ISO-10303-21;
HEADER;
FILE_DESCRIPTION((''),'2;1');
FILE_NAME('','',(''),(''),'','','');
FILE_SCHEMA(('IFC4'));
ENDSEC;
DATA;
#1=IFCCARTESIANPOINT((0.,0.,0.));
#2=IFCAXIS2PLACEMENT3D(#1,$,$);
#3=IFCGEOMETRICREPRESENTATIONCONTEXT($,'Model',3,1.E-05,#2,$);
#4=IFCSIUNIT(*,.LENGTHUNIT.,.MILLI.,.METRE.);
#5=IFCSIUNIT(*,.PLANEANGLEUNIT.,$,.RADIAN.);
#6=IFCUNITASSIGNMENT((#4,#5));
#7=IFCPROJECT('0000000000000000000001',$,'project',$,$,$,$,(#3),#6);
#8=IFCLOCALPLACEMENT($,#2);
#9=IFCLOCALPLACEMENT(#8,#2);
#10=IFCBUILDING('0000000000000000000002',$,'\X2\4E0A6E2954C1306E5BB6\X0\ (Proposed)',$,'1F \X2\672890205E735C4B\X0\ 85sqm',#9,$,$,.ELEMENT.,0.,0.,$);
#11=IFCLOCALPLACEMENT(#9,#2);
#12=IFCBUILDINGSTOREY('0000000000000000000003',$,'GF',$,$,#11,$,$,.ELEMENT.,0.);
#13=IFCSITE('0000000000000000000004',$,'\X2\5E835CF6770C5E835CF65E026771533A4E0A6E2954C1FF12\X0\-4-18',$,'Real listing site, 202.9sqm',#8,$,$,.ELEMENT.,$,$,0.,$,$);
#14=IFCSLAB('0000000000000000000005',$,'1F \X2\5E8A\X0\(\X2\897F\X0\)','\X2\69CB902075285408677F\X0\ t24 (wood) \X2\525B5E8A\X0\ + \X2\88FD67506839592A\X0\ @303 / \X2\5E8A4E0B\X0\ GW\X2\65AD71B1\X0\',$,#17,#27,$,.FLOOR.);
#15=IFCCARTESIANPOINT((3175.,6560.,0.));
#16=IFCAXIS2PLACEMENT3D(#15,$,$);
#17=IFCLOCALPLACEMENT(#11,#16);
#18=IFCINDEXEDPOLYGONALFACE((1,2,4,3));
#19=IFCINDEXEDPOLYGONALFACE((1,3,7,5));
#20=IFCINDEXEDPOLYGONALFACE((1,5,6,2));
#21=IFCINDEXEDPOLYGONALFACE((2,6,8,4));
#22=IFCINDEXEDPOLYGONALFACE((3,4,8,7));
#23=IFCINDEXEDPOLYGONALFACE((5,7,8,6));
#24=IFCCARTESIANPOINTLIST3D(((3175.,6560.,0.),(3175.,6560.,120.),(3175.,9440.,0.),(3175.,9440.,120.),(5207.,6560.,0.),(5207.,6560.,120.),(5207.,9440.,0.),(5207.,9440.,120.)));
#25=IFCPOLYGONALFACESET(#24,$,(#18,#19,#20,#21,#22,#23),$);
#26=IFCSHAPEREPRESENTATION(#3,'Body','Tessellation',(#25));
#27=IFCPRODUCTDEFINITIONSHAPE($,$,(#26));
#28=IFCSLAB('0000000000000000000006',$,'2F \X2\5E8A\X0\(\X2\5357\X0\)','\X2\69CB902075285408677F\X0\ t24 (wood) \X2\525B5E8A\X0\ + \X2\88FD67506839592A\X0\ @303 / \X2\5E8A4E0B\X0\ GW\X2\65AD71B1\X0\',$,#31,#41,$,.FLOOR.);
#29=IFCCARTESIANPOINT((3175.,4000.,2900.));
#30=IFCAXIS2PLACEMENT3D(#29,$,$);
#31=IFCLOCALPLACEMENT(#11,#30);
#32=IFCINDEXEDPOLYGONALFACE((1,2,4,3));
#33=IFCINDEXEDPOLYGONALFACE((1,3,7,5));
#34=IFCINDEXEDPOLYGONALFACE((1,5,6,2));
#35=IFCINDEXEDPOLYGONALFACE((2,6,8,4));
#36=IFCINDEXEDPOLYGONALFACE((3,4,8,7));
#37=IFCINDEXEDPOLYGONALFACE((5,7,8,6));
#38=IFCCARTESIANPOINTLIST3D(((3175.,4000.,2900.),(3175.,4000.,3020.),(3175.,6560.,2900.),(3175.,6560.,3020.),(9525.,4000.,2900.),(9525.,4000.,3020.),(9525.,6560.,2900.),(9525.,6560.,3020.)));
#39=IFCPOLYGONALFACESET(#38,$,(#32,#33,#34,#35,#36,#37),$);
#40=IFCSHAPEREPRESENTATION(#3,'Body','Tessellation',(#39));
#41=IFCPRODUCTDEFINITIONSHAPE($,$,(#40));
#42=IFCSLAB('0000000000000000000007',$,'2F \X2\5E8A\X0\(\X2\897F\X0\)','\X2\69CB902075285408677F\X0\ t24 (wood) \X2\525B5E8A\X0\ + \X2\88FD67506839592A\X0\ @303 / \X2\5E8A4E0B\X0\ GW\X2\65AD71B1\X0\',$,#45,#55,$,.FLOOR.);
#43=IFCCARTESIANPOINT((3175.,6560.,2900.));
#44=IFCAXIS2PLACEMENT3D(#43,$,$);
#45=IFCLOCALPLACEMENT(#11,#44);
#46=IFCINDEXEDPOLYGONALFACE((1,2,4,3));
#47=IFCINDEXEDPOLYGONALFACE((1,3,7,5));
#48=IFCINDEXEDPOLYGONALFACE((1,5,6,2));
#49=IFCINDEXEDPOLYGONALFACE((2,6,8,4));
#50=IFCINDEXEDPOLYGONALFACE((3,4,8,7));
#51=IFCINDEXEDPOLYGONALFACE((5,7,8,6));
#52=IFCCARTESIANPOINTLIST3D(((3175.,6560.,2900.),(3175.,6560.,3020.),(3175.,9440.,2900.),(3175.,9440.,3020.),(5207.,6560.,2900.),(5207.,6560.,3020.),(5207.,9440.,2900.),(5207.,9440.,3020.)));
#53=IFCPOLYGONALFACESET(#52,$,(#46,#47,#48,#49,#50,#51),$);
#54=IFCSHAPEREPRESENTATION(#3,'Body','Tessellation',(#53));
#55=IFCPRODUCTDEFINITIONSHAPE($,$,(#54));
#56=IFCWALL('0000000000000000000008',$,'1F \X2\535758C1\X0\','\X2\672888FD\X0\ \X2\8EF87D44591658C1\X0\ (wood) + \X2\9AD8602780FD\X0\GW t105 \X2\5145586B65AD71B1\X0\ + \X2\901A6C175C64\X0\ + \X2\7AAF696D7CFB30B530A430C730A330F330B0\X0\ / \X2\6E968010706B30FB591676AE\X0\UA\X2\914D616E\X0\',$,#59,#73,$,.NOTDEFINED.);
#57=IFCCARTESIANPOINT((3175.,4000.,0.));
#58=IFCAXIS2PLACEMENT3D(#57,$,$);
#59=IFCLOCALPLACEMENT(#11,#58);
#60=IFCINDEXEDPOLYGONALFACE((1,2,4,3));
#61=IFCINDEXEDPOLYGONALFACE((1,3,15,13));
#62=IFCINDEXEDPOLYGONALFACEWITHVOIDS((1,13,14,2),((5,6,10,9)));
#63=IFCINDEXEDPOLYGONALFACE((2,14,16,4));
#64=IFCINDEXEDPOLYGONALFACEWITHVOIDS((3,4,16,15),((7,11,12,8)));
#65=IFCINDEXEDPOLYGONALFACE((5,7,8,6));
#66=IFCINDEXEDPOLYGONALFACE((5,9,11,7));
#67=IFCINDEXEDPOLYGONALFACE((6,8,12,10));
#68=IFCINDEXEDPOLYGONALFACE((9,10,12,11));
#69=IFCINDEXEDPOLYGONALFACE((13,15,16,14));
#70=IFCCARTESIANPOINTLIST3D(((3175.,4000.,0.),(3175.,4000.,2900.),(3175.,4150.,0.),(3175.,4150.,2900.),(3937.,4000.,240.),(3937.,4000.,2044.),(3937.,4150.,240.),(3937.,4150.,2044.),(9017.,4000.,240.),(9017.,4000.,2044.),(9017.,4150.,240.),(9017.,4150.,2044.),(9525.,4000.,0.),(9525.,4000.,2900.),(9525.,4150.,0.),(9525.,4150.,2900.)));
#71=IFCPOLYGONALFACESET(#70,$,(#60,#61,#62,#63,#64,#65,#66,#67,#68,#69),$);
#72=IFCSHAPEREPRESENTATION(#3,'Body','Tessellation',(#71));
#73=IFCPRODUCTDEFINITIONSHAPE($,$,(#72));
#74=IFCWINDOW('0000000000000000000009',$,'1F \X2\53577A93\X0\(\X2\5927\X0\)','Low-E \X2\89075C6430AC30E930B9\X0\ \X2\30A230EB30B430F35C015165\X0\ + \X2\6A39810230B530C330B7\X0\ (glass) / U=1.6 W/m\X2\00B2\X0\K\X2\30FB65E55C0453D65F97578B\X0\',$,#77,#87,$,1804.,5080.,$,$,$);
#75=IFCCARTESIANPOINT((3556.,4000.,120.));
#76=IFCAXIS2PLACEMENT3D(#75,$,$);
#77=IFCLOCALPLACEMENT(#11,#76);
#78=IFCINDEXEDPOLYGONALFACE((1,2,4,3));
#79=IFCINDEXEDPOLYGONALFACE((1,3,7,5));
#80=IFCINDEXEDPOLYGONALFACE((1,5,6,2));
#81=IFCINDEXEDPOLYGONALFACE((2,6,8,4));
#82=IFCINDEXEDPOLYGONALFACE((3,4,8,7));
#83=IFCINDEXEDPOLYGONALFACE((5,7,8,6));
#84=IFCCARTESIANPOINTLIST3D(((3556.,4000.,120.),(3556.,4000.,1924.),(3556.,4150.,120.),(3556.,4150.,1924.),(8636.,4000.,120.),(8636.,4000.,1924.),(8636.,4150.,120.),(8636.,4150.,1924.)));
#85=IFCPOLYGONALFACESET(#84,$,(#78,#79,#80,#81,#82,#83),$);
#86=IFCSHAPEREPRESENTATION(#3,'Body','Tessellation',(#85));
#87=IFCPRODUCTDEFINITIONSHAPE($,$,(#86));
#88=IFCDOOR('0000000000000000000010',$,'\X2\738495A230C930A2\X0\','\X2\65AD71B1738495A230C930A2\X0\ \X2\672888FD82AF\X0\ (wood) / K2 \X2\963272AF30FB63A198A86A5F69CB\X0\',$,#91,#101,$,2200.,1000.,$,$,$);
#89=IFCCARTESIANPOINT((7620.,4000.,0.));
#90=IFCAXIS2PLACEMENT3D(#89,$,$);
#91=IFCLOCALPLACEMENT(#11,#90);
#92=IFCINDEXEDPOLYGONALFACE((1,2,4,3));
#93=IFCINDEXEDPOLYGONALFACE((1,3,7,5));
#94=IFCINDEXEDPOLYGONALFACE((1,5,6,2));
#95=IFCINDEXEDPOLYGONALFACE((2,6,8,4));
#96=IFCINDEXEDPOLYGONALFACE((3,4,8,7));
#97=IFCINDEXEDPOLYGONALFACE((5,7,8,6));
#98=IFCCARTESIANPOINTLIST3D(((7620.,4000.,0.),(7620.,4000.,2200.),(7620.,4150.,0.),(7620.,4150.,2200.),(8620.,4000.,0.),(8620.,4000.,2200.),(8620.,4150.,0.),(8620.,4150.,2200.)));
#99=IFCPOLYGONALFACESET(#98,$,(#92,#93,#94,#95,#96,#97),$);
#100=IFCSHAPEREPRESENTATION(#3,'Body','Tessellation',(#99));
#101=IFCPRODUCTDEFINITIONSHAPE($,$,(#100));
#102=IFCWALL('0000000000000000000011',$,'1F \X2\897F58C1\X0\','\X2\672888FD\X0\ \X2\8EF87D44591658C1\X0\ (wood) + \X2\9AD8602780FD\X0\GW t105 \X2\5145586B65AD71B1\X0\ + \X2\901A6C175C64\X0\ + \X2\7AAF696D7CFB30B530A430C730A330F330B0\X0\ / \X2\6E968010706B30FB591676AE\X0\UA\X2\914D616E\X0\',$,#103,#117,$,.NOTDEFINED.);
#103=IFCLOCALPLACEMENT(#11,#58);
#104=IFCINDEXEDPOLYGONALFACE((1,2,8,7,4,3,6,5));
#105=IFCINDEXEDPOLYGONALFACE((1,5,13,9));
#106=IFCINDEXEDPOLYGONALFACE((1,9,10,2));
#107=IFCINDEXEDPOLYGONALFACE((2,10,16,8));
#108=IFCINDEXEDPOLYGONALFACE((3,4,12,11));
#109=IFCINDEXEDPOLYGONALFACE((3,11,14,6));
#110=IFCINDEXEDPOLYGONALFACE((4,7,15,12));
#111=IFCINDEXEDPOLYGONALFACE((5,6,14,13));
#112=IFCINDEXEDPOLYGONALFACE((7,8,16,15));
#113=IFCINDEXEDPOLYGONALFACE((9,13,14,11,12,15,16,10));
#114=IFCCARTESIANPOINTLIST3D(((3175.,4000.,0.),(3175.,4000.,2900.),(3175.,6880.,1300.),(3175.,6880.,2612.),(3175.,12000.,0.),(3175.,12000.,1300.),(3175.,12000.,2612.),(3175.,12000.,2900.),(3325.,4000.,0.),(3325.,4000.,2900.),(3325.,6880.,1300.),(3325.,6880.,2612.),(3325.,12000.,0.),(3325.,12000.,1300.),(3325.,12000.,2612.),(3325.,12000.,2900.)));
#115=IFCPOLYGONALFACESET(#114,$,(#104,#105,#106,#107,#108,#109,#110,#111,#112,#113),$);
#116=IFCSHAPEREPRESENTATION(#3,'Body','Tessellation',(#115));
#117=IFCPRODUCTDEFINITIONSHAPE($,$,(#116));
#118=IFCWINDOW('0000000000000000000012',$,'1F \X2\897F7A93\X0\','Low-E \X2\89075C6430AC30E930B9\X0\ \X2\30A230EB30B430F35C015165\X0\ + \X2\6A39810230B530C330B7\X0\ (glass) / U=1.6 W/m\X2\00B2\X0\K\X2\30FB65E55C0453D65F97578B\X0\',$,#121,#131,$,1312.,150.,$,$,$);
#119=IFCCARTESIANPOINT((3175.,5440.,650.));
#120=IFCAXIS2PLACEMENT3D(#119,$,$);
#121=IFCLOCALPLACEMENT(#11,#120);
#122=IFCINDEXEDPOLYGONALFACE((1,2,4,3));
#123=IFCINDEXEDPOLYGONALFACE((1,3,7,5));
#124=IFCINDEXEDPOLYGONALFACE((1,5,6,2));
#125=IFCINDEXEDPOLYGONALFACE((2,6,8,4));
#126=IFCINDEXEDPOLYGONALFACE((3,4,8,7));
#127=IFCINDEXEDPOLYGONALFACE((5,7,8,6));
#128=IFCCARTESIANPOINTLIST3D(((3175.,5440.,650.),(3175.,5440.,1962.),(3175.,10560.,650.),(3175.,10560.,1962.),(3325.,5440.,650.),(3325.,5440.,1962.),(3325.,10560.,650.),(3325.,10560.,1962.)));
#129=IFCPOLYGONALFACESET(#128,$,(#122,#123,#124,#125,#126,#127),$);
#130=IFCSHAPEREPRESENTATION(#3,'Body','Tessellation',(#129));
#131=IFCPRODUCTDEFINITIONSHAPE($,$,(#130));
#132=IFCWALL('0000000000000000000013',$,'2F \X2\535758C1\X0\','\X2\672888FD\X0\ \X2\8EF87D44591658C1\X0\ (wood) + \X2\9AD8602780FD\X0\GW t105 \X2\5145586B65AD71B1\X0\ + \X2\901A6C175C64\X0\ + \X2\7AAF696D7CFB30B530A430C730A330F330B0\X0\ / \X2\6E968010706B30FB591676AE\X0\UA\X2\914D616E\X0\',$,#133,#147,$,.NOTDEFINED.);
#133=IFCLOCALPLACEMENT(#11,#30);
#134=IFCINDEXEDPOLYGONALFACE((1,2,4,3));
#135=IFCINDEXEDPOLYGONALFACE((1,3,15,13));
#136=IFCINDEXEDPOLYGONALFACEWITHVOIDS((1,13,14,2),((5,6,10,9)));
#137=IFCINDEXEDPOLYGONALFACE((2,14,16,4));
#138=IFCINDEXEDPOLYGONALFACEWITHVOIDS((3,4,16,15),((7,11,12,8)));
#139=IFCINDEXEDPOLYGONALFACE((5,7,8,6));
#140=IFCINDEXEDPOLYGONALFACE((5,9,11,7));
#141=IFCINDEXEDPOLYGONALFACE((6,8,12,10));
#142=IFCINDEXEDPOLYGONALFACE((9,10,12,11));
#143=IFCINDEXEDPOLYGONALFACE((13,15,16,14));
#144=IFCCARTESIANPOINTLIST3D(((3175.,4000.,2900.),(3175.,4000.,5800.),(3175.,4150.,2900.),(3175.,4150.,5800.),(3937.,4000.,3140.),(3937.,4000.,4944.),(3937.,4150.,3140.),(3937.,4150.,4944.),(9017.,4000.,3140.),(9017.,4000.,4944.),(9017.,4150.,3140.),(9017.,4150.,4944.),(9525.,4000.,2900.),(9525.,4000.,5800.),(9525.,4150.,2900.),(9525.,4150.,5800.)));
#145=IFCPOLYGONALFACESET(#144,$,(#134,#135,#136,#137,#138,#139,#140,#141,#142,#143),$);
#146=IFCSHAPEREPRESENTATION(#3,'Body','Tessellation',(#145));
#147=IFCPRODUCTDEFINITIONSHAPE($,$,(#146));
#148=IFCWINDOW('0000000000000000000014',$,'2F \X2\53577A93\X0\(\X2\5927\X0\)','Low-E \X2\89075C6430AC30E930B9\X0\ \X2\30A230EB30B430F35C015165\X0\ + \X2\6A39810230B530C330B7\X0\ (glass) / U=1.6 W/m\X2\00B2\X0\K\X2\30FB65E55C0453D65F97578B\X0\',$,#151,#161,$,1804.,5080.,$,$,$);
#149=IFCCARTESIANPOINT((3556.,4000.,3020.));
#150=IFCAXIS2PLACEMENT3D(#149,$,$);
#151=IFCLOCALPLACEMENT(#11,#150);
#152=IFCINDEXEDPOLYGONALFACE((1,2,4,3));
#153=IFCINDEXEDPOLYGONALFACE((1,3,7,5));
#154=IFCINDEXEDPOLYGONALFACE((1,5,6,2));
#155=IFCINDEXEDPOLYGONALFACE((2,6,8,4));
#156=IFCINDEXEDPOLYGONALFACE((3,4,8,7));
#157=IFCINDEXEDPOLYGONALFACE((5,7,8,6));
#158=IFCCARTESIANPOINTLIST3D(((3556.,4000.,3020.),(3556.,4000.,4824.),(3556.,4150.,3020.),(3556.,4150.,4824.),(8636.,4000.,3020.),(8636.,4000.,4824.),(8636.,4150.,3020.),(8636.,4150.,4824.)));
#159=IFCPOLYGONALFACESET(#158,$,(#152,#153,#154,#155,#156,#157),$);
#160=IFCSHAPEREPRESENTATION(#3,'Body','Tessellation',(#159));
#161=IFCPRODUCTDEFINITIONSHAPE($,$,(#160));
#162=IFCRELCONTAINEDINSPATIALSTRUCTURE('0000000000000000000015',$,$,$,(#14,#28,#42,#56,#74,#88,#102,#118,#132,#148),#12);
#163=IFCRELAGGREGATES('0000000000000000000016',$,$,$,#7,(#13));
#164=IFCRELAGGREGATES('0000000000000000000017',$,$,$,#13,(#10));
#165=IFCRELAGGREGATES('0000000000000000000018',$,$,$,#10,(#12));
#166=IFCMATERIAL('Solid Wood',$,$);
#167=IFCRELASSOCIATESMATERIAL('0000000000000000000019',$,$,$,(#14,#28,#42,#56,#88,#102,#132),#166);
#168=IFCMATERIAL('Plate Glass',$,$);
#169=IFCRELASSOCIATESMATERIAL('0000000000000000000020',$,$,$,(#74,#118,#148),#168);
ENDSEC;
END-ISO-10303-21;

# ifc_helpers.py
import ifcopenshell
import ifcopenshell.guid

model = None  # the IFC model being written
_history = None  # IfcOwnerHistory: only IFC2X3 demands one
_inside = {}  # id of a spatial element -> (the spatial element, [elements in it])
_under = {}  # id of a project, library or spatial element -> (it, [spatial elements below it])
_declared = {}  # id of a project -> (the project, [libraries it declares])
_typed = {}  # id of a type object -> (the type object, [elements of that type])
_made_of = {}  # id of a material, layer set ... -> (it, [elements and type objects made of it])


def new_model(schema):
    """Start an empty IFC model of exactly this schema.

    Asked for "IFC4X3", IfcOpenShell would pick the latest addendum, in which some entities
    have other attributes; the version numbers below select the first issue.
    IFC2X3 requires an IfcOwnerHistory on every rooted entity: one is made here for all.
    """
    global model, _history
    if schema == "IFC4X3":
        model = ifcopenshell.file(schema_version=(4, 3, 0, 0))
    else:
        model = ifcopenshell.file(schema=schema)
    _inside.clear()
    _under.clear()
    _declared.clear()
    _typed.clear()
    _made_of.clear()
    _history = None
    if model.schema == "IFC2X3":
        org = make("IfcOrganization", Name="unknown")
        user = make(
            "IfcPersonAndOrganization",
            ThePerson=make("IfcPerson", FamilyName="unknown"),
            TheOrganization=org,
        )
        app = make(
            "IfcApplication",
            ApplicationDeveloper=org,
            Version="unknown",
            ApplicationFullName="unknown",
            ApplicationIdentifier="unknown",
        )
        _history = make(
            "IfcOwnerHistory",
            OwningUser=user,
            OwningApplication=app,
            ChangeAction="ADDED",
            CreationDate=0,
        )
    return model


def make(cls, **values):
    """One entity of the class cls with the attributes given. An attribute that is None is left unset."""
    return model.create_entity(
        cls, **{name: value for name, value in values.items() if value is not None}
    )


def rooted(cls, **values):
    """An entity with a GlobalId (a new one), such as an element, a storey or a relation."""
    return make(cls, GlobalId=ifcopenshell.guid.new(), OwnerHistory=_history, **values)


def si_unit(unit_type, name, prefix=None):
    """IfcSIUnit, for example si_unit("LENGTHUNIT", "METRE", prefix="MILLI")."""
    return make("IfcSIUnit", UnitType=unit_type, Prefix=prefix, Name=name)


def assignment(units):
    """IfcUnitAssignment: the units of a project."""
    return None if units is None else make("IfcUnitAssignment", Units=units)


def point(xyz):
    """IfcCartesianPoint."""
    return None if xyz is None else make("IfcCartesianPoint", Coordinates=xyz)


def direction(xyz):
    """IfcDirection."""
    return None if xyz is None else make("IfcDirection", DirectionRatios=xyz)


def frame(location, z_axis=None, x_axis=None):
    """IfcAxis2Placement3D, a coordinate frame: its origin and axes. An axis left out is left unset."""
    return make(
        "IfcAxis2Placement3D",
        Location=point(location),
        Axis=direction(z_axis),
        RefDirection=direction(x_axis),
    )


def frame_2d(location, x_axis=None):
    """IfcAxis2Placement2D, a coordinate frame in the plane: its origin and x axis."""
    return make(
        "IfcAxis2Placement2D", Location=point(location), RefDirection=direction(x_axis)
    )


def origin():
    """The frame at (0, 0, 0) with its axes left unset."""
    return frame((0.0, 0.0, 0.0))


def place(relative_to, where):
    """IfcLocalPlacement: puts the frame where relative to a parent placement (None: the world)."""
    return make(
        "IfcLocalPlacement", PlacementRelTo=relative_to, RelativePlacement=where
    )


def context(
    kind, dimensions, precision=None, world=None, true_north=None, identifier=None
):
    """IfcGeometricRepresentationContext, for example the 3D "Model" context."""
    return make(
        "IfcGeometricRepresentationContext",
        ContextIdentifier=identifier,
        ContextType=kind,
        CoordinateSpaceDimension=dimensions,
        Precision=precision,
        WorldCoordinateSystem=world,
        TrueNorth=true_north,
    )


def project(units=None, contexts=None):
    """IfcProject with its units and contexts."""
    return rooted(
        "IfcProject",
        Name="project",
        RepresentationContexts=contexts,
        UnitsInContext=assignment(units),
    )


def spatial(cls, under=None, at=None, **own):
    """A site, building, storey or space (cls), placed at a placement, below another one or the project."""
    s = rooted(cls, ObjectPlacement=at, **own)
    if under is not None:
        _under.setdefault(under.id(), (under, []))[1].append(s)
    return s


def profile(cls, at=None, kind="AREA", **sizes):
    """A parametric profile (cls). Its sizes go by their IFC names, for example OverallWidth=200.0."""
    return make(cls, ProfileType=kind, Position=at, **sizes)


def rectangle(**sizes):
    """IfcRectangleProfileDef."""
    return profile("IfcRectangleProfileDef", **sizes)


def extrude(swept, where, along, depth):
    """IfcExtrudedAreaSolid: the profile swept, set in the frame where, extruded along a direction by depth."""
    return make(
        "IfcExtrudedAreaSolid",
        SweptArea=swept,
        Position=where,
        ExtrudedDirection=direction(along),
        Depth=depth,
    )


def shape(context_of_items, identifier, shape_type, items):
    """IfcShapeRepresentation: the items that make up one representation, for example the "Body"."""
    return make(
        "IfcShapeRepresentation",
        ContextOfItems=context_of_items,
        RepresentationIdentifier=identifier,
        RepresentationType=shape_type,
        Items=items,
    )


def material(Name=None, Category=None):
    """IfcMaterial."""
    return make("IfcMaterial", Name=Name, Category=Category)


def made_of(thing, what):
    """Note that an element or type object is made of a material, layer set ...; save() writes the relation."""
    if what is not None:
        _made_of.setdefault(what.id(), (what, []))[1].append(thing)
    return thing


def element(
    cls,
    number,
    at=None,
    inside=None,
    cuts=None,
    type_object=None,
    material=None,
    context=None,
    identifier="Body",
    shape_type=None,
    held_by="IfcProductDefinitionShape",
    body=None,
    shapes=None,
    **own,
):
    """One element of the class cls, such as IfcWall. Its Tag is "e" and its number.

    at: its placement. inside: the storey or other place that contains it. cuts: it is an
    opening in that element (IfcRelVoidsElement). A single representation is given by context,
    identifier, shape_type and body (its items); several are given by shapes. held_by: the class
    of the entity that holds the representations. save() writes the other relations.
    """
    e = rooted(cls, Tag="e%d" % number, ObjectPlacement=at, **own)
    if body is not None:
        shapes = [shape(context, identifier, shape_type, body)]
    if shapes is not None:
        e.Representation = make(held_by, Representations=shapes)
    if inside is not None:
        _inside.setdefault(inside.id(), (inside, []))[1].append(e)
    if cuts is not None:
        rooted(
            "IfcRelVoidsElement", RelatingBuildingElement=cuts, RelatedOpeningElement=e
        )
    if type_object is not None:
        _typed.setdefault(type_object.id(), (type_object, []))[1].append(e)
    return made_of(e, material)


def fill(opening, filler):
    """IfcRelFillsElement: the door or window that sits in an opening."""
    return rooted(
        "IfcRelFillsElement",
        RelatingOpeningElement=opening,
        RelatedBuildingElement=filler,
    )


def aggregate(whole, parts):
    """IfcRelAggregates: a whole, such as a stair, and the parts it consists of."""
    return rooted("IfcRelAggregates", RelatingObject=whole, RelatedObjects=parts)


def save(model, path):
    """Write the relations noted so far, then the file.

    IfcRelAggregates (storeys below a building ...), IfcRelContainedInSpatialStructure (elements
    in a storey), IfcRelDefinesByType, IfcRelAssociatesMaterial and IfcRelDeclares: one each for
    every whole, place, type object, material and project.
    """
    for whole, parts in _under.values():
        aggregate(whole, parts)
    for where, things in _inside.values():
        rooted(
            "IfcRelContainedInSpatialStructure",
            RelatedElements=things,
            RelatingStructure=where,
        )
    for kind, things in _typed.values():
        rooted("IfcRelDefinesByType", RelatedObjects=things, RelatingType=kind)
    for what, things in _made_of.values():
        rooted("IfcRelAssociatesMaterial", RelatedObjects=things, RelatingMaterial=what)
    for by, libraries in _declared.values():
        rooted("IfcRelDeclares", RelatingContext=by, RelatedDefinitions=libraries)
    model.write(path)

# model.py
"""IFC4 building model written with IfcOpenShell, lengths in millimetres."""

from ifc_helpers import new_model, si_unit, frame, frame_2d, origin, place, context, project, spatial, rectangle, extrude, material, element, fill, save


model = new_model("IFC4")

# Units and contexts
model_context = context("Model", 3, precision=1e-05, world=origin())
ifc_project = project(units=[si_unit("LENGTHUNIT", "METRE", prefix="MILLI"), si_unit("PLANEANGLEUNIT", "RADIAN")], contexts=[model_context])

# Site, building, storey
site_placement = place(None, origin())
site = spatial("IfcSite", under=ifc_project, at=site_placement, Name="広島県広島市東区上温品２-4-18", ObjectType="Real listing site, 202.9sqm", CompositionType="ELEMENT", RefElevation=0.0)
building_placement = place(site_placement, origin())
building = spatial("IfcBuilding", under=site, at=building_placement, Name="上温品の家 (Proposed)", ObjectType="1F 木造平屋 85sqm", CompositionType="ELEMENT", ElevationOfRefHeight=0.0, ElevationOfTerrain=0.0)
storey_placement = place(building_placement, origin())
storey = spatial("IfcBuildingStorey", under=building, at=storey_placement, Name="GF", CompositionType="ELEMENT", Elevation=0.0)

# Slabs
ifc_material_1 = material(Name="Solid Wood")
slab_1_placement = place(storey_placement, frame((3175.0, 6560.0, 0.0)))
element("IfcSlab", 1, at=slab_1_placement, inside=storey, material=ifc_material_1, Name="1F 床(西)", Description="構造用合板 t24 (wood) 剛床 + 製材根太 @303 / 床下 GW断熱", PredefinedType="FLOOR", context=model_context, shape_type="SweptSolid", body=[
    extrude(rectangle(XDim=2032.0, YDim=2880.0, at=frame_2d((1016.0, 1440.0))), frame((3175.0, 6560.0, 0.0)), (0.0, 0.0, 1.0), 120.0),
])
slab_2_placement = place(storey_placement, frame((3175.0, 4000.0, 2900.0)))
element("IfcSlab", 2, at=slab_2_placement, inside=storey, material=ifc_material_1, Name="2F 床(南)", Description="構造用合板 t24 (wood) 剛床 + 製材根太 @303 / 床下 GW断熱", PredefinedType="FLOOR", context=model_context, shape_type="SweptSolid", body=[
    extrude(rectangle(XDim=6350.0, YDim=2560.0, at=frame_2d((3175.0, 1280.0))), frame((3175.0, 4000.0, 2900.0)), (0.0, 0.0, 1.0), 120.0),
])
slab_3_placement = place(storey_placement, frame((3175.0, 6560.0, 2900.0)))
element("IfcSlab", 3, at=slab_3_placement, inside=storey, material=ifc_material_1, Name="2F 床(西)", Description="構造用合板 t24 (wood) 剛床 + 製材根太 @303 / 床下 GW断熱", PredefinedType="FLOOR", context=model_context, shape_type="SweptSolid", body=[
    extrude(rectangle(XDim=2032.0, YDim=2880.0, at=frame_2d((1016.0, 1440.0))), frame((3175.0, 6560.0, 2900.0)), (0.0, 0.0, 1.0), 120.0),
])

# Wall, openings, window, door
wall_1_placement = place(storey_placement, frame((3175.0, 4000.0, 0.0)))
wall_1 = element("IfcWall", 4, at=wall_1_placement, inside=storey, material=ifc_material_1, Name="1F 南壁", Description="木製 軸組外壁 (wood) + 高性能GW t105 充填断熱 + 通気層 + 窯業系サイディング / 準耐火・外皮UA配慮", PredefinedType="NOTDEFINED", context=model_context, shape_type="SweptSolid", body=[
    extrude(rectangle(XDim=6350.0, YDim=150.0, at=frame_2d((3175.0, 75.0))), frame((3175.0, 4000.0, 0.0)), (0.0, 0.0, 1.0), 2900.0),
])
opening_1_placement = place(storey_placement, frame((3556.0, 4000.0, 120.0)))
opening_1 = element("IfcOpeningElement", 5, at=opening_1_placement, cuts=wall_1, PredefinedType="NOTDEFINED", context=model_context, shape_type="SweptSolid", body=[
    extrude(rectangle(XDim=5080.0, YDim=150.0, at=frame_2d((2540.0, 75.0))), frame((3556.0, 4000.0, 120.0)), (0.0, 0.0, 1.0), 1804.0),
])
opening_2_placement = place(storey_placement, frame((7620.0, 4000.0, 0.0)))
opening_2 = element("IfcOpeningElement", 6, at=opening_2_placement, cuts=wall_1, PredefinedType="NOTDEFINED", context=model_context, shape_type="SweptSolid", body=[
    extrude(rectangle(XDim=1000.0, YDim=150.0, at=frame_2d((500.0, 75.0))), frame((7620.0, 4000.0, 0.0)), (0.0, 0.0, 1.0), 2200.0),
])
ifc_material_2 = material(Name="Plate Glass")
window_1_placement = place(storey_placement, frame((3556.0, 4000.0, 120.0)))
window_1 = element("IfcWindow", 7, at=window_1_placement, inside=storey, material=ifc_material_2, Name="1F 南窓(大)", Description="Low-E 複層ガラス アルゴン封入 + 樹脂サッシ (glass) / U=1.6 W/m²K・日射取得型", OverallHeight=1804.0, OverallWidth=5080.0, context=model_context, shape_type="SweptSolid", body=[
    extrude(rectangle(XDim=5080.0, YDim=150.0, at=frame_2d((2540.0, 75.0))), frame((3556.0, 4000.0, 120.0)), (0.0, 0.0, 1.0), 1804.0),
])
fill(opening_1, window_1)
door_placement = place(storey_placement, frame((7620.0, 4000.0, 0.0)))
door = element("IfcDoor", 8, at=door_placement, inside=storey, material=ifc_material_1, Name="玄関ドア", Description="断熱玄関ドア 木製芯 (wood) / K2 防犯・採風機構", OverallHeight=2200.0, OverallWidth=1000.0, context=model_context, shape_type="SweptSolid", body=[
    extrude(rectangle(XDim=1000.0, YDim=150.0, at=frame_2d((500.0, 75.0))), frame((7620.0, 4000.0, 0.0)), (0.0, 0.0, 1.0), 2200.0),
])
fill(opening_2, door)

# Walls, openings, windows
wall_2_placement = place(storey_placement, frame((3175.0, 4000.0, 0.0)))
wall_2 = element("IfcWall", 9, at=wall_2_placement, inside=storey, material=ifc_material_1, Name="1F 西壁", Description="木製 軸組外壁 (wood) + 高性能GW t105 充填断熱 + 通気層 + 窯業系サイディング / 準耐火・外皮UA配慮", PredefinedType="NOTDEFINED", context=model_context, shape_type="SweptSolid", body=[
    extrude(rectangle(XDim=150.0, YDim=8000.0, at=frame_2d((75.0, 4000.0))), frame((3175.0, 4000.0, 0.0)), (0.0, 0.0, 1.0), 2900.0),
])
opening_3_placement = place(storey_placement, frame((3175.0, 5440.0, 650.0)))
opening_3 = element("IfcOpeningElement", 10, at=opening_3_placement, cuts=wall_2, PredefinedType="NOTDEFINED", context=model_context, shape_type="SweptSolid", body=[
    extrude(rectangle(XDim=150.0, YDim=5120.0, at=frame_2d((75.0, 2560.0))), frame((3175.0, 5440.0, 650.0)), (0.0, 0.0, 1.0), 1312.0),
])
window_2_placement = place(storey_placement, frame((3175.0, 5440.0, 650.0)))
window_2 = element("IfcWindow", 11, at=window_2_placement, inside=storey, material=ifc_material_2, Name="1F 西窓", Description="Low-E 複層ガラス アルゴン封入 + 樹脂サッシ (glass) / U=1.6 W/m²K・日射取得型", OverallHeight=1312.0, OverallWidth=150.0, context=model_context, shape_type="SweptSolid", body=[
    extrude(rectangle(XDim=150.0, YDim=5120.0, at=frame_2d((75.0, 2560.0))), frame((3175.0, 5440.0, 650.0)), (0.0, 0.0, 1.0), 1312.0),
])
fill(opening_3, window_2)
wall_3_placement = place(storey_placement, frame((3175.0, 4000.0, 2900.0)))
wall_3 = element("IfcWall", 12, at=wall_3_placement, inside=storey, material=ifc_material_1, Name="2F 南壁", Description="木製 軸組外壁 (wood) + 高性能GW t105 充填断熱 + 通気層 + 窯業系サイディング / 準耐火・外皮UA配慮", PredefinedType="NOTDEFINED", context=model_context, shape_type="SweptSolid", body=[
    extrude(rectangle(XDim=6350.0, YDim=150.0, at=frame_2d((3175.0, 75.0))), frame((3175.0, 4000.0, 2900.0)), (0.0, 0.0, 1.0), 2900.0),
])
opening_4_placement = place(storey_placement, frame((3556.0, 4000.0, 3020.0)))
opening_4 = element("IfcOpeningElement", 13, at=opening_4_placement, cuts=wall_3, PredefinedType="NOTDEFINED", context=model_context, shape_type="SweptSolid", body=[
    extrude(rectangle(XDim=5080.0, YDim=150.0, at=frame_2d((2540.0, 75.0))), frame((3556.0, 4000.0, 3020.0)), (0.0, 0.0, 1.0), 1804.0),
])
window_3_placement = place(storey_placement, frame((3556.0, 4000.0, 3020.0)))
window_3 = element("IfcWindow", 14, at=window_3_placement, inside=storey, material=ifc_material_2, Name="2F 南窓(大)", Description="Low-E 複層ガラス アルゴン封入 + 樹脂サッシ (glass) / U=1.6 W/m²K・日射取得型", OverallHeight=1804.0, OverallWidth=5080.0, context=model_context, shape_type="SweptSolid", body=[
    extrude(rectangle(XDim=5080.0, YDim=150.0, at=frame_2d((2540.0, 75.0))), frame((3556.0, 4000.0, 3020.0)), (0.0, 0.0, 1.0), 1804.0),
])
fill(opening_4, window_3)

save(model, "model.ifc")
